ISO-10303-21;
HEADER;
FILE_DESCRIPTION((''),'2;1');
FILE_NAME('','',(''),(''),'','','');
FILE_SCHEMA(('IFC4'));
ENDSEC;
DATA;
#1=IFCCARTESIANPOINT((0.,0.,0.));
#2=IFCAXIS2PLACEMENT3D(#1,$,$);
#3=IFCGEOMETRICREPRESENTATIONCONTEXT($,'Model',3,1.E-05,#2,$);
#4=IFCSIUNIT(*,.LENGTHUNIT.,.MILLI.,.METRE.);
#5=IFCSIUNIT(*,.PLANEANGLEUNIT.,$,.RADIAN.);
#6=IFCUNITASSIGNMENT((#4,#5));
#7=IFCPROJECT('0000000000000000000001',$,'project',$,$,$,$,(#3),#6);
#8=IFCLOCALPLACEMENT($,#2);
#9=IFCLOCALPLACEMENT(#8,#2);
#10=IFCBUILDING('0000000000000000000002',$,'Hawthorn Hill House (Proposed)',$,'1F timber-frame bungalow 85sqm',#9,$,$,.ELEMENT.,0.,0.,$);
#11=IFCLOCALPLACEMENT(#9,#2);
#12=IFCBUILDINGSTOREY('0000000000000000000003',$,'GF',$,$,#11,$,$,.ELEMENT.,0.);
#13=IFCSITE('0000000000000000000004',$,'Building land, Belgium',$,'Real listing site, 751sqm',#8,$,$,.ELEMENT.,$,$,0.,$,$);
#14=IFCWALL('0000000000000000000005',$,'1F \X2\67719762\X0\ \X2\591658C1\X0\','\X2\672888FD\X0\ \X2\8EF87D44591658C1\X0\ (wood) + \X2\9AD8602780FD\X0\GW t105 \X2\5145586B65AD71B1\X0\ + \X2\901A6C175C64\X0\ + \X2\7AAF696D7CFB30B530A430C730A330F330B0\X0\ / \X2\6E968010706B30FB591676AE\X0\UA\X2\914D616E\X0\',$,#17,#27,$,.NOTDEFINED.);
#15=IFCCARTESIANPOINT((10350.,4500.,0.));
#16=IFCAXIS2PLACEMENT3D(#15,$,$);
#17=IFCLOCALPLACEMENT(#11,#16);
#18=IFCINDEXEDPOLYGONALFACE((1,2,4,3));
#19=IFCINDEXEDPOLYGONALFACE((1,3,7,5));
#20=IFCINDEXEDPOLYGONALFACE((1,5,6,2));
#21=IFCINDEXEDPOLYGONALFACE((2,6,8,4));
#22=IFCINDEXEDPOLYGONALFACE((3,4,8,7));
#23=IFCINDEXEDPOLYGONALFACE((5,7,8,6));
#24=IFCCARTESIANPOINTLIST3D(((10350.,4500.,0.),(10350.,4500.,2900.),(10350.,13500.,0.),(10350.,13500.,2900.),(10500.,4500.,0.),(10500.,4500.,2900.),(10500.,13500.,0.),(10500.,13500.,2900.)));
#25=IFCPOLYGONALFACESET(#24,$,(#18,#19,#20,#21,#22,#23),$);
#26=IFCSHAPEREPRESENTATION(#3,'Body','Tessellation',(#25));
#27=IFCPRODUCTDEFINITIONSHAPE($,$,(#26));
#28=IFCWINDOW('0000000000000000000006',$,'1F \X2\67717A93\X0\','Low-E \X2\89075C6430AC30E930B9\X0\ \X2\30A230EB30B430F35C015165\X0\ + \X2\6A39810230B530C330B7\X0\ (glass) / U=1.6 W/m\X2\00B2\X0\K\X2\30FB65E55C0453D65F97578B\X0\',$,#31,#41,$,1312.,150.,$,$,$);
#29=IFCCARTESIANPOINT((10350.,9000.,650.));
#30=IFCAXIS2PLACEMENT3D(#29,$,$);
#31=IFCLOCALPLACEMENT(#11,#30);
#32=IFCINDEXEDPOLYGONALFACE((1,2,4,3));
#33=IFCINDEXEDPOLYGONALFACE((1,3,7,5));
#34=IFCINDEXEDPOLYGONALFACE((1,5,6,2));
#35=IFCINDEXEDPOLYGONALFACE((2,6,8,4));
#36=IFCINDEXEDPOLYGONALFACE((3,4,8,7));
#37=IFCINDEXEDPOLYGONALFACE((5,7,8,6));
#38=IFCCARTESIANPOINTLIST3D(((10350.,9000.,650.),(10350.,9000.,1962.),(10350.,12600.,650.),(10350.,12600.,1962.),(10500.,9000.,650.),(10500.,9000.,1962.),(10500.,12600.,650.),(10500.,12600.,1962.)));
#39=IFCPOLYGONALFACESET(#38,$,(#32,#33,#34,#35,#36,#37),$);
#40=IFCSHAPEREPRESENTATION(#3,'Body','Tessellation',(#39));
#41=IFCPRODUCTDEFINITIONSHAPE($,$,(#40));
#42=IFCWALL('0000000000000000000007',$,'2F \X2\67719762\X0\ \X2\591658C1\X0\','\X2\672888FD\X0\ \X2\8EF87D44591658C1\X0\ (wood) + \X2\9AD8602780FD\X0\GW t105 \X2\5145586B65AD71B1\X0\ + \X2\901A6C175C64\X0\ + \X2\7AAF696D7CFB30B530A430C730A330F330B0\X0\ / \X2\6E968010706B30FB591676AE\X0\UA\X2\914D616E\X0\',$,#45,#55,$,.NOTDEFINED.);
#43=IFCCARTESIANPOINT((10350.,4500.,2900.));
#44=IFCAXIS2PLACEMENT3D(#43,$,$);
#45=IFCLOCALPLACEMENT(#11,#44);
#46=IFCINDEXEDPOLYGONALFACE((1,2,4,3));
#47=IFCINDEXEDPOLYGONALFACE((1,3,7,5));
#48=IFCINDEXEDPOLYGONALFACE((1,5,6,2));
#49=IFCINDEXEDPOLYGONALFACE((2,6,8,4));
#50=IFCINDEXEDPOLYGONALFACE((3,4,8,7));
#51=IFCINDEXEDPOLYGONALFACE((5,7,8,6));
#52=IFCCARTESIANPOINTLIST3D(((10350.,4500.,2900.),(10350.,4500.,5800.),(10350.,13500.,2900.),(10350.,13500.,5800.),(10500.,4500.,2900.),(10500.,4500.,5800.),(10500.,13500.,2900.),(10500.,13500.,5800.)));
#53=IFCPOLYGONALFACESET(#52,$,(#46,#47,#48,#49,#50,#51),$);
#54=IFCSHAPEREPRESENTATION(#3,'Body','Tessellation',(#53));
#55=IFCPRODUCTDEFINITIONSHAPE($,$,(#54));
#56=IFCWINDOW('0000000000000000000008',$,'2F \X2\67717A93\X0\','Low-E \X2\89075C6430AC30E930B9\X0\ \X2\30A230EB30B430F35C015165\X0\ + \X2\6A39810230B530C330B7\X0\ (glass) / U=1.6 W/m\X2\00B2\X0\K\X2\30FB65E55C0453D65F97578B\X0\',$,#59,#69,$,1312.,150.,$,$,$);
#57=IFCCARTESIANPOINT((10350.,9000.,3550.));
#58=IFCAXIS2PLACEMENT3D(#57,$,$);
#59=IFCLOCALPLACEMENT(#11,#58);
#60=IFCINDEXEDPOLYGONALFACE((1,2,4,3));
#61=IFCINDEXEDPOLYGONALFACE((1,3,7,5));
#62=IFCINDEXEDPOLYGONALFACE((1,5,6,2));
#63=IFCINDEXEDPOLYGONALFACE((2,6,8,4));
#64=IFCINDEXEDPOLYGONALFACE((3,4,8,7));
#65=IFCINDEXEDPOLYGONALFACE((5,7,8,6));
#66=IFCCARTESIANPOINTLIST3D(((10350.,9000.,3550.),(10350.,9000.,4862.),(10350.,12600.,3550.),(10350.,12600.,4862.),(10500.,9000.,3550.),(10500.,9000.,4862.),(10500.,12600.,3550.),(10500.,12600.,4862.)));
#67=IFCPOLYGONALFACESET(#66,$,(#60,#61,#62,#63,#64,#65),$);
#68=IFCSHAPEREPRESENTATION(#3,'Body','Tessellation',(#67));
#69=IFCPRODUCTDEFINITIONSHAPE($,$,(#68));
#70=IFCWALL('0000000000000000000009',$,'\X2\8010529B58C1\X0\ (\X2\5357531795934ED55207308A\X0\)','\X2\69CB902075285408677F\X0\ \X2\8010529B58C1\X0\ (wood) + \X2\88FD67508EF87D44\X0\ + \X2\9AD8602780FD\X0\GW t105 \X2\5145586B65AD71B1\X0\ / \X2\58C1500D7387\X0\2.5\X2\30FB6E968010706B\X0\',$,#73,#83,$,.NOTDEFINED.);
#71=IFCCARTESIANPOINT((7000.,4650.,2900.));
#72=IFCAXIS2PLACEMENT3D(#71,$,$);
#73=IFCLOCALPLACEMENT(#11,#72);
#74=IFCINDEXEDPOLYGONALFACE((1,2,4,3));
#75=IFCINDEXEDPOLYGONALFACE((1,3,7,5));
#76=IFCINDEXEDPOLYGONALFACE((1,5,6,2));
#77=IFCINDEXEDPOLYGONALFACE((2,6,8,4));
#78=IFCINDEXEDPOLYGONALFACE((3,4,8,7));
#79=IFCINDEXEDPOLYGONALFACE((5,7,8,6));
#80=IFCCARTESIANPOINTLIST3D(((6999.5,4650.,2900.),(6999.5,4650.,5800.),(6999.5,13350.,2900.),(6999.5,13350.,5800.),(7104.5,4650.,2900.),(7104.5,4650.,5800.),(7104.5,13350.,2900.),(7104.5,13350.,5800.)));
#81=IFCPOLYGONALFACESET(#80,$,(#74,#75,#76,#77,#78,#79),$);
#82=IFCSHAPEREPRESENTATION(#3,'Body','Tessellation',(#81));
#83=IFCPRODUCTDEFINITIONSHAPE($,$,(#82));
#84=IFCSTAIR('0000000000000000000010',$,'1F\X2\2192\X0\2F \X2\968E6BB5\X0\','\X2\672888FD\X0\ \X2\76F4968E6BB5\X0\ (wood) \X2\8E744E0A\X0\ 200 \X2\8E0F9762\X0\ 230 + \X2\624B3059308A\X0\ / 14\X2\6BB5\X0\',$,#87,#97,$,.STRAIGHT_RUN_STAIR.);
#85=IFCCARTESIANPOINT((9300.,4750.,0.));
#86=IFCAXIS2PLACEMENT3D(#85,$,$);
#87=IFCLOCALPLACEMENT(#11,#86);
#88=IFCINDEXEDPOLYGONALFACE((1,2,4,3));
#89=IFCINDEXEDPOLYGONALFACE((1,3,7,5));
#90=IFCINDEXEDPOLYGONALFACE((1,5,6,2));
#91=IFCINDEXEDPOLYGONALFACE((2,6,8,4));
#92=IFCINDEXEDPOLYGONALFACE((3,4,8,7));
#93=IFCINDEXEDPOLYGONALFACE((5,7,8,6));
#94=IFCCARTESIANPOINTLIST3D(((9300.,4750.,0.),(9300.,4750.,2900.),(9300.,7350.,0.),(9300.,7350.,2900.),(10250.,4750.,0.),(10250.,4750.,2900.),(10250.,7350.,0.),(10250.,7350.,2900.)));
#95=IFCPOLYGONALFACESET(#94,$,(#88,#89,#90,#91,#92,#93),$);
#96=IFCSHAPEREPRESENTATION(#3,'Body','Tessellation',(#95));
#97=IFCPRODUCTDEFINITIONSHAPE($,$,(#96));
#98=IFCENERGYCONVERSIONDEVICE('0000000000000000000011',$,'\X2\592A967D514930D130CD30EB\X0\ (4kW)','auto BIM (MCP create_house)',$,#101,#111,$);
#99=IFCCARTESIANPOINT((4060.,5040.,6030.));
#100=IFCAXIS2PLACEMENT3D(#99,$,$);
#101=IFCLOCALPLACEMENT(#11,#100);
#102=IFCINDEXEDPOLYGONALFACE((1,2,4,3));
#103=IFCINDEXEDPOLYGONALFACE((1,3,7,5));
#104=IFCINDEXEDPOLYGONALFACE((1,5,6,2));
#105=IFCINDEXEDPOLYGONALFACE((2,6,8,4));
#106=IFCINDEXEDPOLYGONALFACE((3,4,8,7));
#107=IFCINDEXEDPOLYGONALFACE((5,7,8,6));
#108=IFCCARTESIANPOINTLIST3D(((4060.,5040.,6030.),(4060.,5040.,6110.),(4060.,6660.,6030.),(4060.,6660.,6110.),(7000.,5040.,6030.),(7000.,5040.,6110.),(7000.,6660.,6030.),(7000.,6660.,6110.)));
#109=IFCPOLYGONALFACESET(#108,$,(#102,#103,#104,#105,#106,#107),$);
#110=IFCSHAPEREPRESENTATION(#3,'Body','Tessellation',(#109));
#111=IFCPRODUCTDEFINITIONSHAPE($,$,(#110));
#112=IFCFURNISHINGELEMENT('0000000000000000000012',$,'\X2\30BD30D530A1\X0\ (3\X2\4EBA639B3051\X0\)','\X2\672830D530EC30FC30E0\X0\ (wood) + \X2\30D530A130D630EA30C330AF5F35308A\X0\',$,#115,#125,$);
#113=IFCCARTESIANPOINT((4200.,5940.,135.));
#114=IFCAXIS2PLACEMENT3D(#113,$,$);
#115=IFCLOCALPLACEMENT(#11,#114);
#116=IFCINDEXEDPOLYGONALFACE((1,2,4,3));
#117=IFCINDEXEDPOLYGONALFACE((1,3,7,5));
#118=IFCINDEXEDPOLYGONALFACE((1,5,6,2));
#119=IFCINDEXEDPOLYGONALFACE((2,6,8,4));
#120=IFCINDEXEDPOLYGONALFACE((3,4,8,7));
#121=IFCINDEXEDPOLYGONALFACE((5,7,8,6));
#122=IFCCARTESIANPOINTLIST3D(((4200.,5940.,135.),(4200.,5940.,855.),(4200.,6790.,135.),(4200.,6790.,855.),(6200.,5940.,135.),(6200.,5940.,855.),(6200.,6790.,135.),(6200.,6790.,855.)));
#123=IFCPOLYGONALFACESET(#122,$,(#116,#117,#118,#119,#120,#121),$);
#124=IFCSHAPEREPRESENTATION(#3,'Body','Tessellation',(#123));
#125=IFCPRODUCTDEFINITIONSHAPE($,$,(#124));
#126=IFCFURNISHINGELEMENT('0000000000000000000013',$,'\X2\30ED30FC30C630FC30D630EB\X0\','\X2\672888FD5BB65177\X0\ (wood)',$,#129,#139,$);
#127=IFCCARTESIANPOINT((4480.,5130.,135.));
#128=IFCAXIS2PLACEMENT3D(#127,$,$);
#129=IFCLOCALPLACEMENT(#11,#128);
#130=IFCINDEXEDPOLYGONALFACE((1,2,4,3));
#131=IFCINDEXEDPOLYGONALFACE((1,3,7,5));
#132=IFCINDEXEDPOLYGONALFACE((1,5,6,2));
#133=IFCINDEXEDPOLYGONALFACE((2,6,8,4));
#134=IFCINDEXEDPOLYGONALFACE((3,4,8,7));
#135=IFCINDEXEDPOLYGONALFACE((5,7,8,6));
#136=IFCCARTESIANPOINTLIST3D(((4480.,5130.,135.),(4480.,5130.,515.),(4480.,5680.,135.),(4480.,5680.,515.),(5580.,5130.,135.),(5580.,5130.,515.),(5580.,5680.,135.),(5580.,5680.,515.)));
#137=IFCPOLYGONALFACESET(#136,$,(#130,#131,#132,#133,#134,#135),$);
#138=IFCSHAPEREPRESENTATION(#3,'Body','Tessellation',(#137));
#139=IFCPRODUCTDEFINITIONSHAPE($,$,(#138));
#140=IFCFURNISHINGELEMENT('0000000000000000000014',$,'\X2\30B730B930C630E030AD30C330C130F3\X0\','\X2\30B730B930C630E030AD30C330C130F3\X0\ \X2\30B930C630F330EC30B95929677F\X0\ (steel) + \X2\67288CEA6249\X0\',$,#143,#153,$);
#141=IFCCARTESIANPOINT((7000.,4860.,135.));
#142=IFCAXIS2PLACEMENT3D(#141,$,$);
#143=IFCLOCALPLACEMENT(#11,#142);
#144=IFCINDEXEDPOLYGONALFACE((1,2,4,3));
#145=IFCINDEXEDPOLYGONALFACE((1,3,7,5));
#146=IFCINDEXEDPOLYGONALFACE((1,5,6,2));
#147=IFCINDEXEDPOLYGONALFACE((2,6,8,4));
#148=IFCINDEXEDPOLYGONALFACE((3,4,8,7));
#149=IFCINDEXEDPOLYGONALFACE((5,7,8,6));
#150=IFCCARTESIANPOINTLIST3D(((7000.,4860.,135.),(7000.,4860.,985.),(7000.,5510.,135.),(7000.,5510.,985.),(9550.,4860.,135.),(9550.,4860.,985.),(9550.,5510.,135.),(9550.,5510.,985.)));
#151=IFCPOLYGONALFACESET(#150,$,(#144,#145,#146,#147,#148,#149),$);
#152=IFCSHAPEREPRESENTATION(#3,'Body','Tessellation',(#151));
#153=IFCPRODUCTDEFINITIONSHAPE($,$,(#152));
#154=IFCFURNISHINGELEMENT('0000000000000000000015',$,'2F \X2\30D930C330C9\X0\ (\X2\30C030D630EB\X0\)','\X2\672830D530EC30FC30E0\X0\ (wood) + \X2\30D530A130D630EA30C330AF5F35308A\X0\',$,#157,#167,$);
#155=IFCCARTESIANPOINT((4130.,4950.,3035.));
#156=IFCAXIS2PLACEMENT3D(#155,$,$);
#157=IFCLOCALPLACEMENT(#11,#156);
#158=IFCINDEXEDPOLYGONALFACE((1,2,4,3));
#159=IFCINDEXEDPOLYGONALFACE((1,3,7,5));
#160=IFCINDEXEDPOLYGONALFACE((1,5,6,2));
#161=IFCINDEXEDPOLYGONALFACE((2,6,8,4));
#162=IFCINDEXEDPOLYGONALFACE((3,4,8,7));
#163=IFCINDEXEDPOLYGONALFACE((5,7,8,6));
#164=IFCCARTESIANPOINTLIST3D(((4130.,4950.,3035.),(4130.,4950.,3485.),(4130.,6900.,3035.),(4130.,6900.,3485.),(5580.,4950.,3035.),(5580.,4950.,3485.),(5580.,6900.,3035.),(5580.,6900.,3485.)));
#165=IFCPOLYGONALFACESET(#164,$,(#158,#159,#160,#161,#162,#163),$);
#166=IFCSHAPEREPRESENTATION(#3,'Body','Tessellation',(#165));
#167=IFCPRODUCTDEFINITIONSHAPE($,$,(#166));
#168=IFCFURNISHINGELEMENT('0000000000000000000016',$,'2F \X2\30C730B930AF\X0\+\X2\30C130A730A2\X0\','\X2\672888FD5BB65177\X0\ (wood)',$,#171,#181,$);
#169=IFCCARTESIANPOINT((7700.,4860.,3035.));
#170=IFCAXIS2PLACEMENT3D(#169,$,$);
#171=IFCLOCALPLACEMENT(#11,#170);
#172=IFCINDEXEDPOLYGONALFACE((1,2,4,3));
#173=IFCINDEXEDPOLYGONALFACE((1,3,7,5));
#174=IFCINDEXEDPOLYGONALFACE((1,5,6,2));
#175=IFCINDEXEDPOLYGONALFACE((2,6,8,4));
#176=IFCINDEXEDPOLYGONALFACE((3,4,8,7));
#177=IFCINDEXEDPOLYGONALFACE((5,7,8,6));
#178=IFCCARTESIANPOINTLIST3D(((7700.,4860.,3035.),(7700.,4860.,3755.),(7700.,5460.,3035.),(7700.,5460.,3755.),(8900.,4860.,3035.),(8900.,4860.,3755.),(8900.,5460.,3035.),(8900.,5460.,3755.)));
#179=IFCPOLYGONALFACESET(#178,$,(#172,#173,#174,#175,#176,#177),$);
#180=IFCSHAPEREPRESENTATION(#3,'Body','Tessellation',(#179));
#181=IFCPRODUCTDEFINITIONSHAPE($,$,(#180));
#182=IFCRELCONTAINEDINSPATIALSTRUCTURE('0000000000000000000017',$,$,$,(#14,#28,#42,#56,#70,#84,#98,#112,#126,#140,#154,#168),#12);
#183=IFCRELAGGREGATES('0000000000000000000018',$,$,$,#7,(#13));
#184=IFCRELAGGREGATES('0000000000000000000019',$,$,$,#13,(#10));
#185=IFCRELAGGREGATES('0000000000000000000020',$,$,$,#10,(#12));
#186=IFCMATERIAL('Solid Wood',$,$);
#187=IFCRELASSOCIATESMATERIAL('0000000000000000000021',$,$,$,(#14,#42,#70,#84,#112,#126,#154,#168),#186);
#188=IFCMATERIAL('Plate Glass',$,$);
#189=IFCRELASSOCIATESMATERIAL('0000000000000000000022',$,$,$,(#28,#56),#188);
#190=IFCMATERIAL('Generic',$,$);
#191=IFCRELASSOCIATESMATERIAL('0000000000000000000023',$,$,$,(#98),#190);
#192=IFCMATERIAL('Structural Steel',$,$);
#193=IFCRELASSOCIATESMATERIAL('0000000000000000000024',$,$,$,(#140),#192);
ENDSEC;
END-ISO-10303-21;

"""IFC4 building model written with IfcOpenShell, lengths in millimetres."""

from ifc_helpers import new_model, si_unit, frame, frame_2d, origin, place, context, project, spatial, rectangle, extrude, material, element, fill, save


model = new_model("IFC4")

# Units and contexts
model_context = context("Model", 3, precision=1e-05, world=origin())
ifc_project = project(units=[si_unit("LENGTHUNIT", "METRE", prefix="MILLI"), si_unit("PLANEANGLEUNIT", "RADIAN")], contexts=[model_context])

# Site, building, storey
site_placement = place(None, origin())
site = spatial("IfcSite", under=ifc_project, at=site_placement, Name="Building land, Belgium", ObjectType="Real listing site, 751sqm", CompositionType="ELEMENT", RefElevation=0.0)
building_placement = place(site_placement, origin())
building = spatial("IfcBuilding", under=site, at=building_placement, Name="Hawthorn Hill House (Proposed)", ObjectType="1F timber-frame bungalow 85sqm", CompositionType="ELEMENT", ElevationOfRefHeight=0.0, ElevationOfTerrain=0.0)
storey_placement = place(building_placement, origin())
storey = spatial("IfcBuildingStorey", under=building, at=storey_placement, Name="GF", CompositionType="ELEMENT", Elevation=0.0)

# Wall, opening, window
ifc_material_1 = material(Name="Solid Wood")
wall_1_placement = place(storey_placement, frame((10350.0, 4500.0, 0.0)))
wall_1 = element("IfcWall", 1, at=wall_1_placement, inside=storey, material=ifc_material_1, Name="1F 東面 外壁", Description="木製 軸組外壁 (wood) + 高性能GW t105 充填断熱 + 通気層 + 窯業系サイディング / 準耐火・外皮UA配慮", PredefinedType="NOTDEFINED", context=model_context, shape_type="SweptSolid", body=[
    extrude(rectangle(XDim=150.0, YDim=9000.0, at=frame_2d((75.0, 4500.0))), frame((10350.0, 4500.0, 0.0)), (0.0, 0.0, 1.0), 2900.0),
])
opening_1_placement = place(storey_placement, frame((10350.0, 9000.0, 650.0)))
opening_1 = element("IfcOpeningElement", 2, at=opening_1_placement, cuts=wall_1, PredefinedType="NOTDEFINED", context=model_context, shape_type="SweptSolid", body=[
    extrude(rectangle(XDim=150.0, YDim=3600.0, at=frame_2d((75.0, 1800.0))), frame((10350.0, 9000.0, 650.0)), (0.0, 0.0, 1.0), 1312.0),
])
ifc_material_2 = material(Name="Plate Glass")
window_1_placement = place(storey_placement, frame((10350.0, 9000.0, 650.0)))
window_1 = element("IfcWindow", 3, at=window_1_placement, inside=storey, material=ifc_material_2, Name="1F 東窓", Description="Low-E 複層ガラス アルゴン封入 + 樹脂サッシ (glass) / U=1.6 W/m²K・日射取得型", OverallHeight=1312.0, OverallWidth=150.0, context=model_context, shape_type="SweptSolid", body=[
    extrude(rectangle(XDim=150.0, YDim=3600.0, at=frame_2d((75.0, 1800.0))), frame((10350.0, 9000.0, 650.0)), (0.0, 0.0, 1.0), 1312.0),
])
fill(opening_1, window_1)

# Wall, opening, window
wall_2_placement = place(storey_placement, frame((10350.0, 4500.0, 2900.0)))
wall_2 = element("IfcWall", 4, at=wall_2_placement, inside=storey, material=ifc_material_1, Name="2F 東面 外壁", Description="木製 軸組外壁 (wood) + 高性能GW t105 充填断熱 + 通気層 + 窯業系サイディング / 準耐火・外皮UA配慮", PredefinedType="NOTDEFINED", context=model_context, shape_type="SweptSolid", body=[
    extrude(rectangle(XDim=150.0, YDim=9000.0, at=frame_2d((75.0, 4500.0))), frame((10350.0, 4500.0, 2900.0)), (0.0, 0.0, 1.0), 2900.0),
])
opening_2_placement = place(storey_placement, frame((10350.0, 9000.0, 3550.0)))
opening_2 = element("IfcOpeningElement", 5, at=opening_2_placement, cuts=wall_2, PredefinedType="NOTDEFINED", context=model_context, shape_type="SweptSolid", body=[
    extrude(rectangle(XDim=150.0, YDim=3600.0, at=frame_2d((75.0, 1800.0))), frame((10350.0, 9000.0, 3550.0)), (0.0, 0.0, 1.0), 1312.0),
])
window_2_placement = place(storey_placement, frame((10350.0, 9000.0, 3550.0)))
window_2 = element("IfcWindow", 6, at=window_2_placement, inside=storey, material=ifc_material_2, Name="2F 東窓", Description="Low-E 複層ガラス アルゴン封入 + 樹脂サッシ (glass) / U=1.6 W/m²K・日射取得型", OverallHeight=1312.0, OverallWidth=150.0, context=model_context, shape_type="SweptSolid", body=[
    extrude(rectangle(XDim=150.0, YDim=3600.0, at=frame_2d((75.0, 1800.0))), frame((10350.0, 9000.0, 3550.0)), (0.0, 0.0, 1.0), 1312.0),
])
fill(opening_2, window_2)

# Wall
wall_3_placement = place(storey_placement, frame((7000.0, 4650.0, 2900.0)))
element("IfcWall", 7, at=wall_3_placement, inside=storey, material=ifc_material_1, Name="耐力壁 (南北間仕切り)", Description="構造用合板 耐力壁 (wood) + 製材軸組 + 高性能GW t105 充填断熱 / 壁倍率2.5・準耐火", PredefinedType="NOTDEFINED", context=model_context, shape_type="SweptSolid", body=[
    extrude(rectangle(XDim=105.0, YDim=8700.0, at=frame_2d((52.0, 4350.0))), frame((7000.0, 4650.0, 2900.0)), (0.0, 0.0, 1.0), 2900.0),
])

# Stair
stair_placement = place(storey_placement, frame((9300.0, 4750.0, 0.0)))
element("IfcStair", 8, at=stair_placement, inside=storey, material=ifc_material_1, Name="1F→2F 階段", Description="木製 直階段 (wood) 蹴上 200 踏面 230 + 手すり / 14段", PredefinedType="STRAIGHT_RUN_STAIR", context=model_context, shape_type="SweptSolid", body=[
    extrude(rectangle(XDim=950.0, YDim=2600.0, at=frame_2d((475.0, 1300.0))), frame((9300.0, 4750.0, 0.0)), (0.0, 0.0, 1.0), 2900.0),
])

# Energy conversion device
ifc_material_3 = material(Name="Generic")
energy_conversion_device_placement = place(storey_placement, frame((4060.0, 5040.0, 6030.0)))
element("IfcEnergyConversionDevice", 9, at=energy_conversion_device_placement, inside=storey, material=ifc_material_3, Name="太陽光パネル (4kW)", Description="auto BIM (MCP create_house)", context=model_context, shape_type="SweptSolid", body=[
    extrude(rectangle(XDim=2940.0, YDim=1620.0, at=frame_2d((1470.0, 810.0))), frame((4060.0, 5040.0, 6030.0)), (0.0, 0.0, 1.0), 80.0),
])

# Furnishing elements
furnishing_1_placement = place(storey_placement, frame((4200.0, 5940.0, 135.0)))
element("IfcFurnishingElement", 10, at=furnishing_1_placement, inside=storey, material=ifc_material_1, Name="ソファ (3人掛け)", Description="木フレーム (wood) + ファブリック張り", context=model_context, shape_type="SweptSolid", body=[
    extrude(rectangle(XDim=2000.0, YDim=850.0, at=frame_2d((1000.0, 425.0))), frame((4200.0, 5940.0, 135.0)), (0.0, 0.0, 1.0), 720.0),
])
furnishing_2_placement = place(storey_placement, frame((4480.0, 5130.0, 135.0)))
element("IfcFurnishingElement", 11, at=furnishing_2_placement, inside=storey, material=ifc_material_1, Name="ローテーブル", Description="木製家具 (wood)", context=model_context, shape_type="SweptSolid", body=[
    extrude(rectangle(XDim=1100.0, YDim=550.0, at=frame_2d((550.0, 275.0))), frame((4480.0, 5130.0, 135.0)), (0.0, 0.0, 1.0), 380.0),
])
ifc_material_4 = material(Name="Structural Steel")
furnishing_3_placement = place(storey_placement, frame((7000.0, 4860.0, 135.0)))
element("IfcFurnishingElement", 12, at=furnishing_3_placement, inside=storey, material=ifc_material_4, Name="システムキッチン", Description="システムキッチン ステンレス天板 (steel) + 木質扉", context=model_context, shape_type="SweptSolid", body=[
    extrude(rectangle(XDim=2550.0, YDim=650.0, at=frame_2d((1275.0, 325.0))), frame((7000.0, 4860.0, 135.0)), (0.0, 0.0, 1.0), 850.0),
])
furnishing_4_placement = place(storey_placement, frame((4130.0, 4950.0, 3035.0)))
element("IfcFurnishingElement", 13, at=furnishing_4_placement, inside=storey, material=ifc_material_1, Name="2F ベッド (ダブル)", Description="木フレーム (wood) + ファブリック張り", context=model_context, shape_type="SweptSolid", body=[
    extrude(rectangle(XDim=1450.0, YDim=1950.0, at=frame_2d((725.0, 975.0))), frame((4130.0, 4950.0, 3035.0)), (0.0, 0.0, 1.0), 450.0),
])
furnishing_5_placement = place(storey_placement, frame((7700.0, 4860.0, 3035.0)))
element("IfcFurnishingElement", 14, at=furnishing_5_placement, inside=storey, material=ifc_material_1, Name="2F デスク+チェア", Description="木製家具 (wood)", context=model_context, shape_type="SweptSolid", body=[
    extrude(rectangle(XDim=1200.0, YDim=600.0, at=frame_2d((600.0, 300.0))), frame((7700.0, 4860.0, 3035.0)), (0.0, 0.0, 1.0), 720.0),
])

save(model, "model.ifc")
